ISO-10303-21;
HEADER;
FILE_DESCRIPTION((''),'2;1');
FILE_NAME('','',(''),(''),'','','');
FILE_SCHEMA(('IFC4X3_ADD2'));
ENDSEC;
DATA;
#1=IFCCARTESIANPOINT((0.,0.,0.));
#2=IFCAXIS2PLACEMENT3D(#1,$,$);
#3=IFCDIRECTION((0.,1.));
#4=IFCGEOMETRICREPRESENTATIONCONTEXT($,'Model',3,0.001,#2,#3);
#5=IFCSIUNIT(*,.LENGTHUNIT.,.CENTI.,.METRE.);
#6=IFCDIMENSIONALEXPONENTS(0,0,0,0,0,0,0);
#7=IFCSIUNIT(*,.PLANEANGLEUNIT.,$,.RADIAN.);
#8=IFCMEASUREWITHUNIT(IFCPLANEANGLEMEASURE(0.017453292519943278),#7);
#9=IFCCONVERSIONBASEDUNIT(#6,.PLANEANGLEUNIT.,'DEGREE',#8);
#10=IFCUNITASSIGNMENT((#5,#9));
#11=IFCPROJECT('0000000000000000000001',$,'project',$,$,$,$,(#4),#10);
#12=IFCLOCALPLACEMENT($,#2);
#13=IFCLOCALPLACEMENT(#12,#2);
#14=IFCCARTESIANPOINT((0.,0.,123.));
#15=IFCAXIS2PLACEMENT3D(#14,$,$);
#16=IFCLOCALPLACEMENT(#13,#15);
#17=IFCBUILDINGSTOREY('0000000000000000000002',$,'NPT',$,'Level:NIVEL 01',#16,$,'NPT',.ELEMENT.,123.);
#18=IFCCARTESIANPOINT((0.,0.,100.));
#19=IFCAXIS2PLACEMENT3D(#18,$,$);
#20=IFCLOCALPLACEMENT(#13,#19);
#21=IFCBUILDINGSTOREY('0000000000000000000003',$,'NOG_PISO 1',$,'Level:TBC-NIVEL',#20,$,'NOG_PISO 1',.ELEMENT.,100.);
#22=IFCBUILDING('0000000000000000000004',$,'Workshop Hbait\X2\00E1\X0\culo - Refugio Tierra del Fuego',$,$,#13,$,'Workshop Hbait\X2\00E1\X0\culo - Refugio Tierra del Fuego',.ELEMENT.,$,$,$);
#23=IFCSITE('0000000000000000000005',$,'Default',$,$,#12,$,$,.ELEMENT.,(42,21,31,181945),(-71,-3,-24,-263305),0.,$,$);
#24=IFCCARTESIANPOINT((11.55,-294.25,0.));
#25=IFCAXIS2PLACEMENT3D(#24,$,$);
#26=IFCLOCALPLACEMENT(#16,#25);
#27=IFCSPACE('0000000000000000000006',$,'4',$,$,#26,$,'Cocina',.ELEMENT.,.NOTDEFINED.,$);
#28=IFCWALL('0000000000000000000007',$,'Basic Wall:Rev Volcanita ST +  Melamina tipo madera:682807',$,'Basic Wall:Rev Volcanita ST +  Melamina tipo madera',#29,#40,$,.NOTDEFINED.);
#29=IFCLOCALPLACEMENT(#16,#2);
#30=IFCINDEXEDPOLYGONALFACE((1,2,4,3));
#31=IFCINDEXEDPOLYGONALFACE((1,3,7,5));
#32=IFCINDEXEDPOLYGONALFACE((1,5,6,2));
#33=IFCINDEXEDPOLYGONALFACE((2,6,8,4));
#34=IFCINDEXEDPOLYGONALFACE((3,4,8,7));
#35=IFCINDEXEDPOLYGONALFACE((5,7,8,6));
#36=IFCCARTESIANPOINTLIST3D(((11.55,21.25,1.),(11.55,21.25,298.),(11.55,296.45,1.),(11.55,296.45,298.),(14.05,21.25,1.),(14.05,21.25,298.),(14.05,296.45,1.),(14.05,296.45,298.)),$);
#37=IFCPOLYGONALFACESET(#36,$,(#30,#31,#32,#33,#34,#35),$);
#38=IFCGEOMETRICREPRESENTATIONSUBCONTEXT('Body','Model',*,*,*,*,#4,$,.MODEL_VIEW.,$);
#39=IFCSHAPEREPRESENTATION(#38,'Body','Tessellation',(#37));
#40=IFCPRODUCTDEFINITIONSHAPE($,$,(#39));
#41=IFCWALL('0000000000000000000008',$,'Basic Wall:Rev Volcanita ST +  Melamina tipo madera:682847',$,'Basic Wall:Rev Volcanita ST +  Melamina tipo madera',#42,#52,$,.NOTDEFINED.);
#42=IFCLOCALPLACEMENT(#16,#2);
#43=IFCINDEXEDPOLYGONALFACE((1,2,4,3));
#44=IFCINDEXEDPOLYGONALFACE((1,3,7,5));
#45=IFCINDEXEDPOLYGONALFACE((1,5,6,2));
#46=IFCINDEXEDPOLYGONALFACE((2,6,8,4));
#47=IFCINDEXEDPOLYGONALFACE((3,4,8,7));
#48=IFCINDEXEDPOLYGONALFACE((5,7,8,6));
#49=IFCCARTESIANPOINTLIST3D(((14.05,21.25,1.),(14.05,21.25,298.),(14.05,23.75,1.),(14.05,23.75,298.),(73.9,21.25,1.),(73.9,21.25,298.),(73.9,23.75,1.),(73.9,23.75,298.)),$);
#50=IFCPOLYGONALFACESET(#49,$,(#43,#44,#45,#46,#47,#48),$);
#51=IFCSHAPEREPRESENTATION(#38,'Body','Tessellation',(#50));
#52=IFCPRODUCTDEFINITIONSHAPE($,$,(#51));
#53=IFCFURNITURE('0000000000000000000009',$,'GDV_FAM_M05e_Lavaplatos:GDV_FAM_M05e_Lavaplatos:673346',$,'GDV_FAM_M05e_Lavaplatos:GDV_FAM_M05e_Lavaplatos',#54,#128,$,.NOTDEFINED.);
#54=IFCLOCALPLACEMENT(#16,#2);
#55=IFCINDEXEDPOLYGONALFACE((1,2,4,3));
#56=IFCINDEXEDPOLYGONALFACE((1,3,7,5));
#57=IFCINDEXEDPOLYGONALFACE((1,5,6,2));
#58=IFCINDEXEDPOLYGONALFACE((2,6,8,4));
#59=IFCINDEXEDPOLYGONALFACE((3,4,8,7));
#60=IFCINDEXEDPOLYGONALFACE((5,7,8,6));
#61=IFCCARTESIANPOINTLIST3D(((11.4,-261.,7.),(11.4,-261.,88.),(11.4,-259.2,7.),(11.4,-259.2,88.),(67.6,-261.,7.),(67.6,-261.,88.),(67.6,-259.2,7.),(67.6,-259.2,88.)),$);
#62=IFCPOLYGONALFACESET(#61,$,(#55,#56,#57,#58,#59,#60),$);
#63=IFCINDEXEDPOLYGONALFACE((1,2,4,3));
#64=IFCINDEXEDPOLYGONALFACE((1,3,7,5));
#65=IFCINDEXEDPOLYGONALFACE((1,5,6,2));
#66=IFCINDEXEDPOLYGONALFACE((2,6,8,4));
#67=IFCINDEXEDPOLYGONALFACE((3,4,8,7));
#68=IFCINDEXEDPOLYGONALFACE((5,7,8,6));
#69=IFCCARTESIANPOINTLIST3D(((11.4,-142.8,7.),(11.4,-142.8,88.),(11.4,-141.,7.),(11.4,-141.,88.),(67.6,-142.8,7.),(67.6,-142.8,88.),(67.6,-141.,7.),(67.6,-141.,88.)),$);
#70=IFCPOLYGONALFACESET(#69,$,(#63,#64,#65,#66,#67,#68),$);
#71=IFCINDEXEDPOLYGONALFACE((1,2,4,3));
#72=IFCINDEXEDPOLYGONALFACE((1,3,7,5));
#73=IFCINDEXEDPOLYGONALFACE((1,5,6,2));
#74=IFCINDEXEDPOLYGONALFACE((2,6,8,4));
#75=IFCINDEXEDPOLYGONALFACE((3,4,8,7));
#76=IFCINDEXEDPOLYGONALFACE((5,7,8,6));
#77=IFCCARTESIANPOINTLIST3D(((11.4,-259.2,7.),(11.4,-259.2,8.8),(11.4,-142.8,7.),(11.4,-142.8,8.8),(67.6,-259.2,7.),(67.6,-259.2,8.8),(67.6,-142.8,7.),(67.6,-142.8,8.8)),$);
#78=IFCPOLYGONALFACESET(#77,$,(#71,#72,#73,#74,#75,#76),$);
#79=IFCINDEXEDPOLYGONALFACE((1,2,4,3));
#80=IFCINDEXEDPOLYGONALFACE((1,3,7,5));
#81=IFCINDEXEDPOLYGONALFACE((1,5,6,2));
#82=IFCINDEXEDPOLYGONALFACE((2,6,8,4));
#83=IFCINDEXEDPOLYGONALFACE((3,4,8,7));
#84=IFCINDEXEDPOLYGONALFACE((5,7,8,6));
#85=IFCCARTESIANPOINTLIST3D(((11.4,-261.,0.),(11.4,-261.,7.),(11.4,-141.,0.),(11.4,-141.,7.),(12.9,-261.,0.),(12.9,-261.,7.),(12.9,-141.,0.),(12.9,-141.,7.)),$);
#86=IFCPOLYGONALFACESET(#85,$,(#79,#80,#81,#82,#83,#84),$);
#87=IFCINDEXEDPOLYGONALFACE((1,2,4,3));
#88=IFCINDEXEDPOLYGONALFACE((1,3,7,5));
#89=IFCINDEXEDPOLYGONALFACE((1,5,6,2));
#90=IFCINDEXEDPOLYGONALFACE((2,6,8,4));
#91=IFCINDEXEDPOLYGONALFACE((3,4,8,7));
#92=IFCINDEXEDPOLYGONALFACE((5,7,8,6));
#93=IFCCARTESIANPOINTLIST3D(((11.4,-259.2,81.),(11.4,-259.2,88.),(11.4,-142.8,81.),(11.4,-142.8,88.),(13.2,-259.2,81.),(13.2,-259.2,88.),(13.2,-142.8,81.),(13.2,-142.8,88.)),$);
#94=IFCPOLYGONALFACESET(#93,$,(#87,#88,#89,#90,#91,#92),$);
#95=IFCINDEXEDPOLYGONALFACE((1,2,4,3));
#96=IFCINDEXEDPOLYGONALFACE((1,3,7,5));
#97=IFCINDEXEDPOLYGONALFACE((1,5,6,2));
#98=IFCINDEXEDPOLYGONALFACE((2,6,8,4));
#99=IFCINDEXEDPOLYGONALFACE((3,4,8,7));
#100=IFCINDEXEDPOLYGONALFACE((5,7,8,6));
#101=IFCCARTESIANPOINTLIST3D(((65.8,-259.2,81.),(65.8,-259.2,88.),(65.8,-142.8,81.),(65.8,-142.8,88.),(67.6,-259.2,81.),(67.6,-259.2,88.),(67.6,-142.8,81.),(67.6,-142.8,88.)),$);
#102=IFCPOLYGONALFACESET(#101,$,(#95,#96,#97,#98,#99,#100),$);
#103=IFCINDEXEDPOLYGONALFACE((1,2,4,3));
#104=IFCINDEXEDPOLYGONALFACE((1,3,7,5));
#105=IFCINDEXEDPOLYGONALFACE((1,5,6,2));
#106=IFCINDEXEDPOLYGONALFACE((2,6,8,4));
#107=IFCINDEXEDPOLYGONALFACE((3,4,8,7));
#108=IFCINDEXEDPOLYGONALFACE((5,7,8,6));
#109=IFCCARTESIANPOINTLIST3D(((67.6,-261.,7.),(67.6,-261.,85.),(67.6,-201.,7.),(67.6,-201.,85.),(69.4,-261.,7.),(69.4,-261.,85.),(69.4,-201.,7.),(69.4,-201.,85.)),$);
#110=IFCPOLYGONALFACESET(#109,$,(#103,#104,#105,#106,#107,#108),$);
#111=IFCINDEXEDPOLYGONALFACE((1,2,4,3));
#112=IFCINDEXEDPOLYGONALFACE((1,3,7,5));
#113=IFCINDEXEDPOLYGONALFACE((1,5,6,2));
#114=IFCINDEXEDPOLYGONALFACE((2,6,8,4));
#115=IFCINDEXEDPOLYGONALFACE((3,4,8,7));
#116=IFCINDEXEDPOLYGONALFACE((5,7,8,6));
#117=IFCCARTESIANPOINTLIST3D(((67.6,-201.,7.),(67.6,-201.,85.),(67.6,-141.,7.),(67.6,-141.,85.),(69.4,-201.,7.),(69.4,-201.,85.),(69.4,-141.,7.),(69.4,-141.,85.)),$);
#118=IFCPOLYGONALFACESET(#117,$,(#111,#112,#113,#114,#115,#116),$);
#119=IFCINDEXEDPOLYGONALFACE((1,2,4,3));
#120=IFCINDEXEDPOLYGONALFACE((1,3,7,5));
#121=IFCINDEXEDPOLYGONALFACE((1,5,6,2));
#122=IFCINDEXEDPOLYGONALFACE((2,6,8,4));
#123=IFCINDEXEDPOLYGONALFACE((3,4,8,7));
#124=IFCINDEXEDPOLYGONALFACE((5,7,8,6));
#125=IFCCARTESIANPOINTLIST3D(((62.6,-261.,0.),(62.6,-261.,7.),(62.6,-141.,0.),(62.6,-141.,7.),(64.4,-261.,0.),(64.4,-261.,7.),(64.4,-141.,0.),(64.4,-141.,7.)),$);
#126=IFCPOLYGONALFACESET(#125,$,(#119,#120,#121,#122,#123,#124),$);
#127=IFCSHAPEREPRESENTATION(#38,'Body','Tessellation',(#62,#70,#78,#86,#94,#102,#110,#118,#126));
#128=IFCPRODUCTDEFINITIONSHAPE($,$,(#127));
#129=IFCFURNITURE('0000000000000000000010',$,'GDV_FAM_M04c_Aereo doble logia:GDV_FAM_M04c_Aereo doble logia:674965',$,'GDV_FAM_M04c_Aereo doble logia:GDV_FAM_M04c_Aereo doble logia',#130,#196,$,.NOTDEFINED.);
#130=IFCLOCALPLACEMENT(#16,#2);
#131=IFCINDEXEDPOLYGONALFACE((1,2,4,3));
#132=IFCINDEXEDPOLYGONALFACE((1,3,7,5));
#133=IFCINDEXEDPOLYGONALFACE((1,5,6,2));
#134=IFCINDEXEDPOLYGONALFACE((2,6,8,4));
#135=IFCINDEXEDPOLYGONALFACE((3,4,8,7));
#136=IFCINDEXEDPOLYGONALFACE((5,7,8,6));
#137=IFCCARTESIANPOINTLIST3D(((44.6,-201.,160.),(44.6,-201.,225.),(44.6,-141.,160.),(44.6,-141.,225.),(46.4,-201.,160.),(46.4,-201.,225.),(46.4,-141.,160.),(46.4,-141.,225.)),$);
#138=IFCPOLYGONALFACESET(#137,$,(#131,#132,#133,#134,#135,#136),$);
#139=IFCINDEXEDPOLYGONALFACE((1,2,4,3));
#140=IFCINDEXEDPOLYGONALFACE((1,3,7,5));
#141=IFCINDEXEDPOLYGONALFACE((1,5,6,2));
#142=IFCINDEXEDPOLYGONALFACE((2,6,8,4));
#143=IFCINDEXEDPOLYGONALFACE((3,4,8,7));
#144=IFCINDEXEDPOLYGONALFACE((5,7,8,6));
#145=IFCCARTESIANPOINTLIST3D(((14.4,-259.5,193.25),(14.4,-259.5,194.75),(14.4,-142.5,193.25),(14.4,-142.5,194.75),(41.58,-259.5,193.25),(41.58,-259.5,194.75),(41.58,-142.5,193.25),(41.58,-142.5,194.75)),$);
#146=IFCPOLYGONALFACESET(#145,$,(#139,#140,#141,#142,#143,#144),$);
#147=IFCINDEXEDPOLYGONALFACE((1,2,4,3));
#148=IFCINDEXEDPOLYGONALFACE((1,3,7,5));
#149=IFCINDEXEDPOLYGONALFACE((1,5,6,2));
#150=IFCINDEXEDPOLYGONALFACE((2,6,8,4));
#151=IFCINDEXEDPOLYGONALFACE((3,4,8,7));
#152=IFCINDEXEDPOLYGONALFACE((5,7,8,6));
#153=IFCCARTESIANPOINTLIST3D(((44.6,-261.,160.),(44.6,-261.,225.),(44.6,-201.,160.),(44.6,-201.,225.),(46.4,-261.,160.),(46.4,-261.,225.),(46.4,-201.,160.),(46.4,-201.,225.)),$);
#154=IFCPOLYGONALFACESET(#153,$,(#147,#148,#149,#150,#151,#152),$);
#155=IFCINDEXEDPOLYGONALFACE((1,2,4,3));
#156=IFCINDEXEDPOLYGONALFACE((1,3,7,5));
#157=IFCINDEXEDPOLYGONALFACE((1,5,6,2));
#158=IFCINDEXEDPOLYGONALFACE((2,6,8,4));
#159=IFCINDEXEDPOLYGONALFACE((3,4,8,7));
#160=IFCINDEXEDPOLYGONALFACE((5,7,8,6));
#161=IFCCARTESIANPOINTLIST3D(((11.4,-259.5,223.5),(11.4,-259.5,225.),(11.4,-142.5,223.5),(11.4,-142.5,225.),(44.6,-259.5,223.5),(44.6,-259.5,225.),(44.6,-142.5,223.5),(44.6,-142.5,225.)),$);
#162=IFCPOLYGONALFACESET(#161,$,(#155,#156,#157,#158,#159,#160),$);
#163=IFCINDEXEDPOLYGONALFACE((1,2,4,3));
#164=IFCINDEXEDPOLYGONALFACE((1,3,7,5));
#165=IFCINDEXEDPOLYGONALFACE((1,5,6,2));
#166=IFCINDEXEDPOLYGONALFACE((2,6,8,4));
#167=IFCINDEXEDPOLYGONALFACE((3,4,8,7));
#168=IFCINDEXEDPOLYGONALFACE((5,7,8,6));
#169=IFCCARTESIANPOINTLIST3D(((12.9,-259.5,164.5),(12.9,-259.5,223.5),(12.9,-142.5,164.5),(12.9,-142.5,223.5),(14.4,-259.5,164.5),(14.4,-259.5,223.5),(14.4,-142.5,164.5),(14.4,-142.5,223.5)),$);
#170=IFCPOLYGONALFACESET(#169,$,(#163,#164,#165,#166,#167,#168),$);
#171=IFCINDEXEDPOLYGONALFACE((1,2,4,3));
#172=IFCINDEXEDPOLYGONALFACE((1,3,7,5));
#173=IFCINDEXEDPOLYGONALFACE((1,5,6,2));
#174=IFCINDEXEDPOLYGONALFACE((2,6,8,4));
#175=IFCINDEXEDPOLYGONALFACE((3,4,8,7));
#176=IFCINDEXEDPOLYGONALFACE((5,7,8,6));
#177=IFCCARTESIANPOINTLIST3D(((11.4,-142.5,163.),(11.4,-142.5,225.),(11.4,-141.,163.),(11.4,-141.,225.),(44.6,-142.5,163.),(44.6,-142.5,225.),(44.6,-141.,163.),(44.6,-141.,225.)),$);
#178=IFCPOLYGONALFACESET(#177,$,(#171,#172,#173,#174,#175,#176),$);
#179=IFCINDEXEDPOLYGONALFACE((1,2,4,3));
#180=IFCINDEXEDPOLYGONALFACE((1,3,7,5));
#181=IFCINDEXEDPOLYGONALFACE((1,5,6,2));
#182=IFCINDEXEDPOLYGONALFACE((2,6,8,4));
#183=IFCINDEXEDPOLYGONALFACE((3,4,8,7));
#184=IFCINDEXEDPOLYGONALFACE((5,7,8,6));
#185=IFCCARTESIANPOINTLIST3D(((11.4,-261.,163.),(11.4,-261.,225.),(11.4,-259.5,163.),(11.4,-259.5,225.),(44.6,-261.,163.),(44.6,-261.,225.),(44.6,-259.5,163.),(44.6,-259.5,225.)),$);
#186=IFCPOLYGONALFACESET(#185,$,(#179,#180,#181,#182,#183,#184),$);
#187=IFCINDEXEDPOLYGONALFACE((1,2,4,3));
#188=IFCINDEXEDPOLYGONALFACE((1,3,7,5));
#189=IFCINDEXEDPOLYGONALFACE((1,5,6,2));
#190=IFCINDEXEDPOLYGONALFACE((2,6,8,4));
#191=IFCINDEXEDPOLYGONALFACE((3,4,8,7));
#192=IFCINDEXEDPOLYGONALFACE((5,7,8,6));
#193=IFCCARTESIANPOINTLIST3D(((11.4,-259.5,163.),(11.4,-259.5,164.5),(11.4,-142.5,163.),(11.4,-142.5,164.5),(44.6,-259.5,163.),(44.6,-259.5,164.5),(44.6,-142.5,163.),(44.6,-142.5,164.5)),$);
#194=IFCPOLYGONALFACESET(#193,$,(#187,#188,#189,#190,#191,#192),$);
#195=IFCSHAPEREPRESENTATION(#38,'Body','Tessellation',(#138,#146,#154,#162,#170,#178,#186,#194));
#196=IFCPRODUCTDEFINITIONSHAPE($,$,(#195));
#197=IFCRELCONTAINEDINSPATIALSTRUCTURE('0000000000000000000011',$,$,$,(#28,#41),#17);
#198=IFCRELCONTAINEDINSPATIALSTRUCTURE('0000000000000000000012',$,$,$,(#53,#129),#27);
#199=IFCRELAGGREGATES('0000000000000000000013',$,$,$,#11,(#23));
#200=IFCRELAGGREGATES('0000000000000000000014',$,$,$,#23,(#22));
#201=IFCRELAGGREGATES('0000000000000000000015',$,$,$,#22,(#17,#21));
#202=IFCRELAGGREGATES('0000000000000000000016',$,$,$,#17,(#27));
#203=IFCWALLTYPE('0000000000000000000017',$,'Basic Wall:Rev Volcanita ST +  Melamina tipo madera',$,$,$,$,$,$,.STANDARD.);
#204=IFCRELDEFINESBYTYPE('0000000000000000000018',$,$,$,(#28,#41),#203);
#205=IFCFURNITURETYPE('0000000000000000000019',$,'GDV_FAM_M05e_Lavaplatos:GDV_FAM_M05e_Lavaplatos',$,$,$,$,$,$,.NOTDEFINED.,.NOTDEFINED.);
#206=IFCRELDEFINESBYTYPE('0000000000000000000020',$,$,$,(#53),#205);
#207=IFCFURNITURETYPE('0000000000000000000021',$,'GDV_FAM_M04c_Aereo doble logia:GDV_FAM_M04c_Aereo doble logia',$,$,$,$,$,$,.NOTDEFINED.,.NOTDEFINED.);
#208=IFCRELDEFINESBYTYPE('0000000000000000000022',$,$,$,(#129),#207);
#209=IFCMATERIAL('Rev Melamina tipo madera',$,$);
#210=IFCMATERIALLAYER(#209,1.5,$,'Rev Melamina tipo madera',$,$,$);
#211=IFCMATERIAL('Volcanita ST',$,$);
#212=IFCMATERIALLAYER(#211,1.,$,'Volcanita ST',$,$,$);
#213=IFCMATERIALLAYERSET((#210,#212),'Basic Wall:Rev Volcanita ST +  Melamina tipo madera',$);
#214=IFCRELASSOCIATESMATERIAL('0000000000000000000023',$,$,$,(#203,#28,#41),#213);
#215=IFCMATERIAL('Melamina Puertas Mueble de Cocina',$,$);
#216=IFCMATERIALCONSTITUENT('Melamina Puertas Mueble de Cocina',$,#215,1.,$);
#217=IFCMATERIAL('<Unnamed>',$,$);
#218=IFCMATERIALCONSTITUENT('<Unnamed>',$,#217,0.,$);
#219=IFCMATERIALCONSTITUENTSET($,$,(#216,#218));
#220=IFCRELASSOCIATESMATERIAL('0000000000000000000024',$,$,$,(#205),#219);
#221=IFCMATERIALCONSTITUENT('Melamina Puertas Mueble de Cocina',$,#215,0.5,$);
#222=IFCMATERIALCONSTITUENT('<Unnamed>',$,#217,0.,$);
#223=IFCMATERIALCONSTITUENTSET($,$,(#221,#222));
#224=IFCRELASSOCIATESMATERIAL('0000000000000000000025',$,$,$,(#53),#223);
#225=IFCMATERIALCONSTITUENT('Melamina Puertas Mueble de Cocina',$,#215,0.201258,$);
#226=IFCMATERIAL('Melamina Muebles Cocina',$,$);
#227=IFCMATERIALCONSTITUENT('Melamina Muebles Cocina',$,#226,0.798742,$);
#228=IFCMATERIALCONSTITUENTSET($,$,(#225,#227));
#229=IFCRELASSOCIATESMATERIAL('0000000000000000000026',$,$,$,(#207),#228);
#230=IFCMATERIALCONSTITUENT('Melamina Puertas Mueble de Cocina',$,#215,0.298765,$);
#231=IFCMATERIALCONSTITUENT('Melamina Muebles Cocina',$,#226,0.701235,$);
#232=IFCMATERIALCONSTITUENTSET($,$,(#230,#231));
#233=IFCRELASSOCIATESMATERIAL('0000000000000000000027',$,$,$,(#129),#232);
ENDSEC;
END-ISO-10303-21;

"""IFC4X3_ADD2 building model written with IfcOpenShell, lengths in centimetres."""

from ifc_helpers import new_model, entity, si_unit, converted_unit, direction, frame, frame_2d, origin, origin_2d_with_axis, place, context, subcontext, project, spatial, rectangle, extrude, source, transform, mapped, material, layer, layer_set, constituent, constituent_set, type_object, type_shapes, element, save


model = new_model("IFC4X3_ADD2")

# Units and contexts
model_context = context("Model", 3, precision=0.001, world=origin(), true_north=direction((0.0, 1.0)))
body_context = subcontext(model_context, "Body", "Model", "MODEL_VIEW")
ifc_project = project(units=[si_unit("LENGTHUNIT", "METRE", prefix="CENTI"), converted_unit("PLANEANGLEUNIT", "DEGREE", entity("IfcPlaneAngleMeasure", 0.017453292519943278), si_unit("PLANEANGLEUNIT", "RADIAN"), dimensions=[0, 0, 0, 0, 0, 0, 0])], contexts=[model_context])

# Site, building, storey
site_placement = place(None, origin())
site = spatial("IfcSite", under=ifc_project, at=site_placement, Name="Default", CompositionType="ELEMENT", RefLatitude=(42, 21, 31, 181945), RefLongitude=(-71, -3, -24, -263305), RefElevation=0.0)
building_placement = place(site_placement, origin())
building = spatial("IfcBuilding", under=site, at=building_placement, Name="Workshop Hbaitáculo - Refugio Tierra del Fuego", LongName="Workshop Hbaitáculo - Refugio Tierra del Fuego", CompositionType="ELEMENT")
storey_1_placement = place(building_placement, frame((0.0, 0.0, 123.0)))
storey_1 = spatial("IfcBuildingStorey", under=building, at=storey_1_placement, Name="NPT", ObjectType="Level:NIVEL 01", LongName="NPT", CompositionType="ELEMENT", Elevation=123.0)

# Shared definitions
storey_2_placement = place(building_placement, frame((0.0, 0.0, 100.0)))
storey_2 = spatial("IfcBuildingStorey", under=building, at=storey_2_placement, Name="NOG_PISO 1", ObjectType="Level:TBC-NIVEL", LongName="NOG_PISO 1", CompositionType="ELEMENT", Elevation=100.0)

# Shared definitions
ifc_material_1 = material(Name="Rev Melamina tipo madera")
ifc_layer_1 = layer(ifc_material_1, 1.5, Name="Rev Melamina tipo madera")
ifc_material_2 = material(Name="Volcanita ST")
ifc_layer_2 = layer(ifc_material_2, 1.0, Name="Volcanita ST")
ifc_layer_set_1 = layer_set([ifc_layer_1, ifc_layer_2], Name="Basic Wall:Rev Volcanita ST +  Melamina tipo madera")
wall_type_1 = type_object("IfcWallType", Name="Basic Wall:Rev Volcanita ST +  Melamina tipo madera", PredefinedType="STANDARD", material=ifc_layer_set_1)

# Walls
wall_1_placement = place(storey_1_placement, frame((12.8, 296.45, 1.0), z_axis=(0.0, 0.0, 1.0), x_axis=(0.0, -1.0, 0.0)))
element("IfcWall", 1, at=wall_1_placement, inside=storey_1, type_object=wall_type_1, material=ifc_layer_set_1, Name="Basic Wall:Rev Volcanita ST +  Melamina tipo madera:682807", ObjectType="Basic Wall:Rev Volcanita ST +  Melamina tipo madera", PredefinedType="NOTDEFINED", context=body_context, shape_type="SweptSolid", body=[
    extrude(rectangle(XDim=275.2, YDim=2.5, at=frame_2d((137.6, 0.0), x_axis=(-1.0, 0.0))), origin(), (0.0, 0.0, 1.0), 297.0),
])
wall_2_placement = place(storey_1_placement, frame((14.05, 22.5, 1.0)))
element("IfcWall", 2, at=wall_2_placement, inside=storey_1, type_object=wall_type_1, material=ifc_layer_set_1, Name="Basic Wall:Rev Volcanita ST +  Melamina tipo madera:682847", ObjectType="Basic Wall:Rev Volcanita ST +  Melamina tipo madera", PredefinedType="NOTDEFINED", context=body_context, shape_type="SweptSolid", body=[
    extrude(rectangle(XDim=59.85, YDim=2.5, at=frame_2d((29.93, 0.0), x_axis=(-1.0, 0.0))), origin(), (0.0, 0.0, 1.0), 297.0),
])

# Shared definitions
space_placement = place(storey_1_placement, frame((11.55, -294.25, 0.0)))
space = spatial("IfcSpace", under=storey_1, at=space_placement, Name="4", LongName="Cocina", CompositionType="ELEMENT", PredefinedType="NOTDEFINED")

# Furniture
ifc_material_3 = material(Name="Melamina Puertas Mueble de Cocina")
ifc_constituent_1 = constituent(ifc_material_3, Name="Melamina Puertas Mueble de Cocina", fraction=0.5)
ifc_material_4 = material(Name="<Unnamed>")
ifc_constituent_2 = constituent(ifc_material_4, Name="<Unnamed>", fraction=0.0)
ifc_constituent_set_1 = constituent_set(constituents=[ifc_constituent_1, ifc_constituent_2])
ifc_constituent_3 = constituent(ifc_material_3, Name="Melamina Puertas Mueble de Cocina", fraction=1.0)
ifc_constituent_4 = constituent(ifc_material_4, Name="<Unnamed>", fraction=0.0)
ifc_constituent_set_2 = constituent_set(constituents=[ifc_constituent_3, ifc_constituent_4])
furniture_type_1 = type_object("IfcFurnitureType", Name="GDV_FAM_M05e_Lavaplatos:GDV_FAM_M05e_Lavaplatos", AssemblyPlace="NOTDEFINED", PredefinedType="NOTDEFINED", material=ifc_constituent_set_2)
shared_shape_1 = source(origin(), body_context, "Body", "SweptSolid", [
    extrude(rectangle(XDim=1.8, YDim=56.2, at=frame_2d((0.0, 0.0), x_axis=(1.0, 0.0))), frame((39.5, -260.1, 7.0), z_axis=(0.0, 0.0, 1.0), x_axis=(0.0, -1.0, 0.0)), (0.0, 0.0, 1.0), 81.0),
    extrude(rectangle(XDim=1.8, YDim=56.2, at=origin_2d_with_axis()), frame((39.5, -141.9, 7.0), z_axis=(0.0, 0.0, 1.0), x_axis=(0.0, -1.0, 0.0)), (0.0, 0.0, 1.0), 81.0),
    extrude(rectangle(XDim=116.4, YDim=56.2, at=frame_2d((0.0, 0.0), x_axis=(1.0, 0.0))), frame((39.5, -201.0, 7.0), z_axis=(0.0, 0.0, 1.0), x_axis=(0.0, -1.0, 0.0)), (0.0, 0.0, 1.0), 1.8),
    extrude(rectangle(XDim=120.0, YDim=1.5, at=origin_2d_with_axis()), frame((12.15, -201.0, 0.0), z_axis=(0.0, 0.0, 1.0), x_axis=(0.0, -1.0, 0.0)), (0.0, 0.0, 1.0), 7.0),
    extrude(rectangle(XDim=116.4, YDim=1.8, at=frame_2d((0.0, 0.0), x_axis=(1.0, 0.0))), frame((12.3, -201.0, 81.0), z_axis=(0.0, 0.0, 1.0), x_axis=(0.0, -1.0, 0.0)), (0.0, 0.0, 1.0), 7.0),
    extrude(rectangle(XDim=116.4, YDim=1.8, at=frame_2d((0.0, 0.0), x_axis=(1.0, 0.0))), frame((66.7, -201.0, 81.0), z_axis=(0.0, 0.0, 1.0), x_axis=(0.0, -1.0, 0.0)), (0.0, 0.0, 1.0), 7.0),
    extrude(rectangle(XDim=60.0, YDim=1.8, at=frame_2d((0.0, 0.0), x_axis=(1.0, 0.0))), frame((68.5, -231.0, 7.0), z_axis=(0.0, 0.0, 1.0), x_axis=(0.0, -1.0, 0.0)), (0.0, 0.0, 1.0), 78.0),
    extrude(rectangle(XDim=60.0, YDim=1.8, at=frame_2d((0.0, 0.0), x_axis=(1.0, 0.0))), frame((68.5, -171.0, 7.0), z_axis=(0.0, 0.0, 1.0), x_axis=(0.0, -1.0, 0.0)), (0.0, 0.0, 1.0), 78.0),
    extrude(rectangle(XDim=120.0, YDim=1.8, at=origin_2d_with_axis()), frame((63.5, -201.0, 0.0), z_axis=(0.0, 0.0, 1.0), x_axis=(0.0, -1.0, 0.0)), (0.0, 0.0, 1.0), 7.0),
])
type_shapes(furniture_type_1, [shared_shape_1])
furniture_1_placement = place(space_placement, frame((-11.55, 294.25, 0.0)))
element("IfcFurniture", 3, at=furniture_1_placement, inside=space, type_object=furniture_type_1, material=ifc_constituent_set_1, Name="GDV_FAM_M05e_Lavaplatos:GDV_FAM_M05e_Lavaplatos:673346", ObjectType="GDV_FAM_M05e_Lavaplatos:GDV_FAM_M05e_Lavaplatos", PredefinedType="NOTDEFINED", context=body_context, shape_type="MappedRepresentation", body=[
    mapped(shared_shape_1, transform((0.0, 0.0, 0.0), scale=1.0)),
])
ifc_constituent_5 = constituent(ifc_material_3, Name="Melamina Puertas Mueble de Cocina", fraction=0.298765)
ifc_material_5 = material(Name="Melamina Muebles Cocina")
ifc_constituent_6 = constituent(ifc_material_5, Name="Melamina Muebles Cocina", fraction=0.701235)
ifc_constituent_set_3 = constituent_set(constituents=[ifc_constituent_5, ifc_constituent_6])
ifc_constituent_7 = constituent(ifc_material_3, Name="Melamina Puertas Mueble de Cocina", fraction=0.201258)
ifc_constituent_8 = constituent(ifc_material_5, Name="Melamina Muebles Cocina", fraction=0.798742)
ifc_constituent_set_4 = constituent_set(constituents=[ifc_constituent_7, ifc_constituent_8])
furniture_type_2 = type_object("IfcFurnitureType", Name="GDV_FAM_M04c_Aereo doble logia:GDV_FAM_M04c_Aereo doble logia", AssemblyPlace="NOTDEFINED", PredefinedType="NOTDEFINED", material=ifc_constituent_set_4)
shared_shape_2 = source(origin(), body_context, "Body", "SweptSolid", [
    extrude(rectangle(XDim=60.0, YDim=1.8, at=frame_2d((0.0, 0.0), x_axis=(1.0, 0.0))), frame((90.0, -34.1, 0.0), z_axis=(0.0, 0.0, 1.0), x_axis=(-1.0, 0.0, 0.0)), (0.0, 0.0, 1.0), 65.0),
    extrude(rectangle(XDim=117.0, YDim=27.18, at=origin_2d_with_axis()), frame((60.0, -16.59, 33.25), z_axis=(0.0, 0.0, 1.0), x_axis=(-1.0, 0.0, 0.0)), (0.0, 0.0, 1.0), 1.5),
    extrude(rectangle(XDim=60.0, YDim=1.8, at=frame_2d((0.0, 0.0), x_axis=(1.0, 0.0))), frame((30.0, -34.1, 0.0), z_axis=(0.0, 0.0, 1.0), x_axis=(-1.0, 0.0, 0.0)), (0.0, 0.0, 1.0), 65.0),
    extrude(rectangle(XDim=117.0, YDim=33.2, at=origin_2d_with_axis()), frame((60.0, -16.6, 63.5), z_axis=(0.0, 0.0, 1.0), x_axis=(-1.0, 0.0, 0.0)), (0.0, 0.0, 1.0), 1.5),
    extrude(rectangle(XDim=117.0, YDim=1.5, at=origin_2d_with_axis()), frame((60.0, -2.25, 4.5), z_axis=(0.0, 0.0, 1.0), x_axis=(-1.0, 0.0, 0.0)), (0.0, 0.0, 1.0), 59.0),
    extrude(rectangle(XDim=33.2, YDim=1.5, at=origin_2d_with_axis()), frame((119.25, -16.6, 3.0), z_axis=(0.0, 0.0, 1.0), x_axis=(0.0, 1.0, 0.0)), (0.0, 0.0, 1.0), 62.0),
    extrude(rectangle(XDim=33.2, YDim=1.5, at=origin_2d_with_axis()), frame((0.75, -16.6, 3.0), z_axis=(0.0, 0.0, 1.0), x_axis=(0.0, 1.0, 0.0)), (0.0, 0.0, 1.0), 62.0),
    extrude(rectangle(XDim=117.0, YDim=33.2, at=origin_2d_with_axis()), frame((60.0, -16.6, 3.0), z_axis=(0.0, 0.0, 1.0), x_axis=(-1.0, 0.0, 0.0)), (0.0, 0.0, 1.0), 1.5),
])
type_shapes(furniture_type_2, [shared_shape_2])
furniture_2_placement = place(space_placement, frame((-0.15, 33.25, 160.0), z_axis=(0.0, 0.0, 1.0), x_axis=(0.0, 1.0, 0.0)))
element("IfcFurniture", 4, at=furniture_2_placement, inside=space, type_object=furniture_type_2, material=ifc_constituent_set_3, Name="GDV_FAM_M04c_Aereo doble logia:GDV_FAM_M04c_Aereo doble logia:674965", ObjectType="GDV_FAM_M04c_Aereo doble logia:GDV_FAM_M04c_Aereo doble logia", PredefinedType="NOTDEFINED", context=body_context, shape_type="MappedRepresentation", body=[
    mapped(shared_shape_2, transform((0.0, 0.0, 0.0), scale=1.0)),
])

save(model, "model.ifc")
